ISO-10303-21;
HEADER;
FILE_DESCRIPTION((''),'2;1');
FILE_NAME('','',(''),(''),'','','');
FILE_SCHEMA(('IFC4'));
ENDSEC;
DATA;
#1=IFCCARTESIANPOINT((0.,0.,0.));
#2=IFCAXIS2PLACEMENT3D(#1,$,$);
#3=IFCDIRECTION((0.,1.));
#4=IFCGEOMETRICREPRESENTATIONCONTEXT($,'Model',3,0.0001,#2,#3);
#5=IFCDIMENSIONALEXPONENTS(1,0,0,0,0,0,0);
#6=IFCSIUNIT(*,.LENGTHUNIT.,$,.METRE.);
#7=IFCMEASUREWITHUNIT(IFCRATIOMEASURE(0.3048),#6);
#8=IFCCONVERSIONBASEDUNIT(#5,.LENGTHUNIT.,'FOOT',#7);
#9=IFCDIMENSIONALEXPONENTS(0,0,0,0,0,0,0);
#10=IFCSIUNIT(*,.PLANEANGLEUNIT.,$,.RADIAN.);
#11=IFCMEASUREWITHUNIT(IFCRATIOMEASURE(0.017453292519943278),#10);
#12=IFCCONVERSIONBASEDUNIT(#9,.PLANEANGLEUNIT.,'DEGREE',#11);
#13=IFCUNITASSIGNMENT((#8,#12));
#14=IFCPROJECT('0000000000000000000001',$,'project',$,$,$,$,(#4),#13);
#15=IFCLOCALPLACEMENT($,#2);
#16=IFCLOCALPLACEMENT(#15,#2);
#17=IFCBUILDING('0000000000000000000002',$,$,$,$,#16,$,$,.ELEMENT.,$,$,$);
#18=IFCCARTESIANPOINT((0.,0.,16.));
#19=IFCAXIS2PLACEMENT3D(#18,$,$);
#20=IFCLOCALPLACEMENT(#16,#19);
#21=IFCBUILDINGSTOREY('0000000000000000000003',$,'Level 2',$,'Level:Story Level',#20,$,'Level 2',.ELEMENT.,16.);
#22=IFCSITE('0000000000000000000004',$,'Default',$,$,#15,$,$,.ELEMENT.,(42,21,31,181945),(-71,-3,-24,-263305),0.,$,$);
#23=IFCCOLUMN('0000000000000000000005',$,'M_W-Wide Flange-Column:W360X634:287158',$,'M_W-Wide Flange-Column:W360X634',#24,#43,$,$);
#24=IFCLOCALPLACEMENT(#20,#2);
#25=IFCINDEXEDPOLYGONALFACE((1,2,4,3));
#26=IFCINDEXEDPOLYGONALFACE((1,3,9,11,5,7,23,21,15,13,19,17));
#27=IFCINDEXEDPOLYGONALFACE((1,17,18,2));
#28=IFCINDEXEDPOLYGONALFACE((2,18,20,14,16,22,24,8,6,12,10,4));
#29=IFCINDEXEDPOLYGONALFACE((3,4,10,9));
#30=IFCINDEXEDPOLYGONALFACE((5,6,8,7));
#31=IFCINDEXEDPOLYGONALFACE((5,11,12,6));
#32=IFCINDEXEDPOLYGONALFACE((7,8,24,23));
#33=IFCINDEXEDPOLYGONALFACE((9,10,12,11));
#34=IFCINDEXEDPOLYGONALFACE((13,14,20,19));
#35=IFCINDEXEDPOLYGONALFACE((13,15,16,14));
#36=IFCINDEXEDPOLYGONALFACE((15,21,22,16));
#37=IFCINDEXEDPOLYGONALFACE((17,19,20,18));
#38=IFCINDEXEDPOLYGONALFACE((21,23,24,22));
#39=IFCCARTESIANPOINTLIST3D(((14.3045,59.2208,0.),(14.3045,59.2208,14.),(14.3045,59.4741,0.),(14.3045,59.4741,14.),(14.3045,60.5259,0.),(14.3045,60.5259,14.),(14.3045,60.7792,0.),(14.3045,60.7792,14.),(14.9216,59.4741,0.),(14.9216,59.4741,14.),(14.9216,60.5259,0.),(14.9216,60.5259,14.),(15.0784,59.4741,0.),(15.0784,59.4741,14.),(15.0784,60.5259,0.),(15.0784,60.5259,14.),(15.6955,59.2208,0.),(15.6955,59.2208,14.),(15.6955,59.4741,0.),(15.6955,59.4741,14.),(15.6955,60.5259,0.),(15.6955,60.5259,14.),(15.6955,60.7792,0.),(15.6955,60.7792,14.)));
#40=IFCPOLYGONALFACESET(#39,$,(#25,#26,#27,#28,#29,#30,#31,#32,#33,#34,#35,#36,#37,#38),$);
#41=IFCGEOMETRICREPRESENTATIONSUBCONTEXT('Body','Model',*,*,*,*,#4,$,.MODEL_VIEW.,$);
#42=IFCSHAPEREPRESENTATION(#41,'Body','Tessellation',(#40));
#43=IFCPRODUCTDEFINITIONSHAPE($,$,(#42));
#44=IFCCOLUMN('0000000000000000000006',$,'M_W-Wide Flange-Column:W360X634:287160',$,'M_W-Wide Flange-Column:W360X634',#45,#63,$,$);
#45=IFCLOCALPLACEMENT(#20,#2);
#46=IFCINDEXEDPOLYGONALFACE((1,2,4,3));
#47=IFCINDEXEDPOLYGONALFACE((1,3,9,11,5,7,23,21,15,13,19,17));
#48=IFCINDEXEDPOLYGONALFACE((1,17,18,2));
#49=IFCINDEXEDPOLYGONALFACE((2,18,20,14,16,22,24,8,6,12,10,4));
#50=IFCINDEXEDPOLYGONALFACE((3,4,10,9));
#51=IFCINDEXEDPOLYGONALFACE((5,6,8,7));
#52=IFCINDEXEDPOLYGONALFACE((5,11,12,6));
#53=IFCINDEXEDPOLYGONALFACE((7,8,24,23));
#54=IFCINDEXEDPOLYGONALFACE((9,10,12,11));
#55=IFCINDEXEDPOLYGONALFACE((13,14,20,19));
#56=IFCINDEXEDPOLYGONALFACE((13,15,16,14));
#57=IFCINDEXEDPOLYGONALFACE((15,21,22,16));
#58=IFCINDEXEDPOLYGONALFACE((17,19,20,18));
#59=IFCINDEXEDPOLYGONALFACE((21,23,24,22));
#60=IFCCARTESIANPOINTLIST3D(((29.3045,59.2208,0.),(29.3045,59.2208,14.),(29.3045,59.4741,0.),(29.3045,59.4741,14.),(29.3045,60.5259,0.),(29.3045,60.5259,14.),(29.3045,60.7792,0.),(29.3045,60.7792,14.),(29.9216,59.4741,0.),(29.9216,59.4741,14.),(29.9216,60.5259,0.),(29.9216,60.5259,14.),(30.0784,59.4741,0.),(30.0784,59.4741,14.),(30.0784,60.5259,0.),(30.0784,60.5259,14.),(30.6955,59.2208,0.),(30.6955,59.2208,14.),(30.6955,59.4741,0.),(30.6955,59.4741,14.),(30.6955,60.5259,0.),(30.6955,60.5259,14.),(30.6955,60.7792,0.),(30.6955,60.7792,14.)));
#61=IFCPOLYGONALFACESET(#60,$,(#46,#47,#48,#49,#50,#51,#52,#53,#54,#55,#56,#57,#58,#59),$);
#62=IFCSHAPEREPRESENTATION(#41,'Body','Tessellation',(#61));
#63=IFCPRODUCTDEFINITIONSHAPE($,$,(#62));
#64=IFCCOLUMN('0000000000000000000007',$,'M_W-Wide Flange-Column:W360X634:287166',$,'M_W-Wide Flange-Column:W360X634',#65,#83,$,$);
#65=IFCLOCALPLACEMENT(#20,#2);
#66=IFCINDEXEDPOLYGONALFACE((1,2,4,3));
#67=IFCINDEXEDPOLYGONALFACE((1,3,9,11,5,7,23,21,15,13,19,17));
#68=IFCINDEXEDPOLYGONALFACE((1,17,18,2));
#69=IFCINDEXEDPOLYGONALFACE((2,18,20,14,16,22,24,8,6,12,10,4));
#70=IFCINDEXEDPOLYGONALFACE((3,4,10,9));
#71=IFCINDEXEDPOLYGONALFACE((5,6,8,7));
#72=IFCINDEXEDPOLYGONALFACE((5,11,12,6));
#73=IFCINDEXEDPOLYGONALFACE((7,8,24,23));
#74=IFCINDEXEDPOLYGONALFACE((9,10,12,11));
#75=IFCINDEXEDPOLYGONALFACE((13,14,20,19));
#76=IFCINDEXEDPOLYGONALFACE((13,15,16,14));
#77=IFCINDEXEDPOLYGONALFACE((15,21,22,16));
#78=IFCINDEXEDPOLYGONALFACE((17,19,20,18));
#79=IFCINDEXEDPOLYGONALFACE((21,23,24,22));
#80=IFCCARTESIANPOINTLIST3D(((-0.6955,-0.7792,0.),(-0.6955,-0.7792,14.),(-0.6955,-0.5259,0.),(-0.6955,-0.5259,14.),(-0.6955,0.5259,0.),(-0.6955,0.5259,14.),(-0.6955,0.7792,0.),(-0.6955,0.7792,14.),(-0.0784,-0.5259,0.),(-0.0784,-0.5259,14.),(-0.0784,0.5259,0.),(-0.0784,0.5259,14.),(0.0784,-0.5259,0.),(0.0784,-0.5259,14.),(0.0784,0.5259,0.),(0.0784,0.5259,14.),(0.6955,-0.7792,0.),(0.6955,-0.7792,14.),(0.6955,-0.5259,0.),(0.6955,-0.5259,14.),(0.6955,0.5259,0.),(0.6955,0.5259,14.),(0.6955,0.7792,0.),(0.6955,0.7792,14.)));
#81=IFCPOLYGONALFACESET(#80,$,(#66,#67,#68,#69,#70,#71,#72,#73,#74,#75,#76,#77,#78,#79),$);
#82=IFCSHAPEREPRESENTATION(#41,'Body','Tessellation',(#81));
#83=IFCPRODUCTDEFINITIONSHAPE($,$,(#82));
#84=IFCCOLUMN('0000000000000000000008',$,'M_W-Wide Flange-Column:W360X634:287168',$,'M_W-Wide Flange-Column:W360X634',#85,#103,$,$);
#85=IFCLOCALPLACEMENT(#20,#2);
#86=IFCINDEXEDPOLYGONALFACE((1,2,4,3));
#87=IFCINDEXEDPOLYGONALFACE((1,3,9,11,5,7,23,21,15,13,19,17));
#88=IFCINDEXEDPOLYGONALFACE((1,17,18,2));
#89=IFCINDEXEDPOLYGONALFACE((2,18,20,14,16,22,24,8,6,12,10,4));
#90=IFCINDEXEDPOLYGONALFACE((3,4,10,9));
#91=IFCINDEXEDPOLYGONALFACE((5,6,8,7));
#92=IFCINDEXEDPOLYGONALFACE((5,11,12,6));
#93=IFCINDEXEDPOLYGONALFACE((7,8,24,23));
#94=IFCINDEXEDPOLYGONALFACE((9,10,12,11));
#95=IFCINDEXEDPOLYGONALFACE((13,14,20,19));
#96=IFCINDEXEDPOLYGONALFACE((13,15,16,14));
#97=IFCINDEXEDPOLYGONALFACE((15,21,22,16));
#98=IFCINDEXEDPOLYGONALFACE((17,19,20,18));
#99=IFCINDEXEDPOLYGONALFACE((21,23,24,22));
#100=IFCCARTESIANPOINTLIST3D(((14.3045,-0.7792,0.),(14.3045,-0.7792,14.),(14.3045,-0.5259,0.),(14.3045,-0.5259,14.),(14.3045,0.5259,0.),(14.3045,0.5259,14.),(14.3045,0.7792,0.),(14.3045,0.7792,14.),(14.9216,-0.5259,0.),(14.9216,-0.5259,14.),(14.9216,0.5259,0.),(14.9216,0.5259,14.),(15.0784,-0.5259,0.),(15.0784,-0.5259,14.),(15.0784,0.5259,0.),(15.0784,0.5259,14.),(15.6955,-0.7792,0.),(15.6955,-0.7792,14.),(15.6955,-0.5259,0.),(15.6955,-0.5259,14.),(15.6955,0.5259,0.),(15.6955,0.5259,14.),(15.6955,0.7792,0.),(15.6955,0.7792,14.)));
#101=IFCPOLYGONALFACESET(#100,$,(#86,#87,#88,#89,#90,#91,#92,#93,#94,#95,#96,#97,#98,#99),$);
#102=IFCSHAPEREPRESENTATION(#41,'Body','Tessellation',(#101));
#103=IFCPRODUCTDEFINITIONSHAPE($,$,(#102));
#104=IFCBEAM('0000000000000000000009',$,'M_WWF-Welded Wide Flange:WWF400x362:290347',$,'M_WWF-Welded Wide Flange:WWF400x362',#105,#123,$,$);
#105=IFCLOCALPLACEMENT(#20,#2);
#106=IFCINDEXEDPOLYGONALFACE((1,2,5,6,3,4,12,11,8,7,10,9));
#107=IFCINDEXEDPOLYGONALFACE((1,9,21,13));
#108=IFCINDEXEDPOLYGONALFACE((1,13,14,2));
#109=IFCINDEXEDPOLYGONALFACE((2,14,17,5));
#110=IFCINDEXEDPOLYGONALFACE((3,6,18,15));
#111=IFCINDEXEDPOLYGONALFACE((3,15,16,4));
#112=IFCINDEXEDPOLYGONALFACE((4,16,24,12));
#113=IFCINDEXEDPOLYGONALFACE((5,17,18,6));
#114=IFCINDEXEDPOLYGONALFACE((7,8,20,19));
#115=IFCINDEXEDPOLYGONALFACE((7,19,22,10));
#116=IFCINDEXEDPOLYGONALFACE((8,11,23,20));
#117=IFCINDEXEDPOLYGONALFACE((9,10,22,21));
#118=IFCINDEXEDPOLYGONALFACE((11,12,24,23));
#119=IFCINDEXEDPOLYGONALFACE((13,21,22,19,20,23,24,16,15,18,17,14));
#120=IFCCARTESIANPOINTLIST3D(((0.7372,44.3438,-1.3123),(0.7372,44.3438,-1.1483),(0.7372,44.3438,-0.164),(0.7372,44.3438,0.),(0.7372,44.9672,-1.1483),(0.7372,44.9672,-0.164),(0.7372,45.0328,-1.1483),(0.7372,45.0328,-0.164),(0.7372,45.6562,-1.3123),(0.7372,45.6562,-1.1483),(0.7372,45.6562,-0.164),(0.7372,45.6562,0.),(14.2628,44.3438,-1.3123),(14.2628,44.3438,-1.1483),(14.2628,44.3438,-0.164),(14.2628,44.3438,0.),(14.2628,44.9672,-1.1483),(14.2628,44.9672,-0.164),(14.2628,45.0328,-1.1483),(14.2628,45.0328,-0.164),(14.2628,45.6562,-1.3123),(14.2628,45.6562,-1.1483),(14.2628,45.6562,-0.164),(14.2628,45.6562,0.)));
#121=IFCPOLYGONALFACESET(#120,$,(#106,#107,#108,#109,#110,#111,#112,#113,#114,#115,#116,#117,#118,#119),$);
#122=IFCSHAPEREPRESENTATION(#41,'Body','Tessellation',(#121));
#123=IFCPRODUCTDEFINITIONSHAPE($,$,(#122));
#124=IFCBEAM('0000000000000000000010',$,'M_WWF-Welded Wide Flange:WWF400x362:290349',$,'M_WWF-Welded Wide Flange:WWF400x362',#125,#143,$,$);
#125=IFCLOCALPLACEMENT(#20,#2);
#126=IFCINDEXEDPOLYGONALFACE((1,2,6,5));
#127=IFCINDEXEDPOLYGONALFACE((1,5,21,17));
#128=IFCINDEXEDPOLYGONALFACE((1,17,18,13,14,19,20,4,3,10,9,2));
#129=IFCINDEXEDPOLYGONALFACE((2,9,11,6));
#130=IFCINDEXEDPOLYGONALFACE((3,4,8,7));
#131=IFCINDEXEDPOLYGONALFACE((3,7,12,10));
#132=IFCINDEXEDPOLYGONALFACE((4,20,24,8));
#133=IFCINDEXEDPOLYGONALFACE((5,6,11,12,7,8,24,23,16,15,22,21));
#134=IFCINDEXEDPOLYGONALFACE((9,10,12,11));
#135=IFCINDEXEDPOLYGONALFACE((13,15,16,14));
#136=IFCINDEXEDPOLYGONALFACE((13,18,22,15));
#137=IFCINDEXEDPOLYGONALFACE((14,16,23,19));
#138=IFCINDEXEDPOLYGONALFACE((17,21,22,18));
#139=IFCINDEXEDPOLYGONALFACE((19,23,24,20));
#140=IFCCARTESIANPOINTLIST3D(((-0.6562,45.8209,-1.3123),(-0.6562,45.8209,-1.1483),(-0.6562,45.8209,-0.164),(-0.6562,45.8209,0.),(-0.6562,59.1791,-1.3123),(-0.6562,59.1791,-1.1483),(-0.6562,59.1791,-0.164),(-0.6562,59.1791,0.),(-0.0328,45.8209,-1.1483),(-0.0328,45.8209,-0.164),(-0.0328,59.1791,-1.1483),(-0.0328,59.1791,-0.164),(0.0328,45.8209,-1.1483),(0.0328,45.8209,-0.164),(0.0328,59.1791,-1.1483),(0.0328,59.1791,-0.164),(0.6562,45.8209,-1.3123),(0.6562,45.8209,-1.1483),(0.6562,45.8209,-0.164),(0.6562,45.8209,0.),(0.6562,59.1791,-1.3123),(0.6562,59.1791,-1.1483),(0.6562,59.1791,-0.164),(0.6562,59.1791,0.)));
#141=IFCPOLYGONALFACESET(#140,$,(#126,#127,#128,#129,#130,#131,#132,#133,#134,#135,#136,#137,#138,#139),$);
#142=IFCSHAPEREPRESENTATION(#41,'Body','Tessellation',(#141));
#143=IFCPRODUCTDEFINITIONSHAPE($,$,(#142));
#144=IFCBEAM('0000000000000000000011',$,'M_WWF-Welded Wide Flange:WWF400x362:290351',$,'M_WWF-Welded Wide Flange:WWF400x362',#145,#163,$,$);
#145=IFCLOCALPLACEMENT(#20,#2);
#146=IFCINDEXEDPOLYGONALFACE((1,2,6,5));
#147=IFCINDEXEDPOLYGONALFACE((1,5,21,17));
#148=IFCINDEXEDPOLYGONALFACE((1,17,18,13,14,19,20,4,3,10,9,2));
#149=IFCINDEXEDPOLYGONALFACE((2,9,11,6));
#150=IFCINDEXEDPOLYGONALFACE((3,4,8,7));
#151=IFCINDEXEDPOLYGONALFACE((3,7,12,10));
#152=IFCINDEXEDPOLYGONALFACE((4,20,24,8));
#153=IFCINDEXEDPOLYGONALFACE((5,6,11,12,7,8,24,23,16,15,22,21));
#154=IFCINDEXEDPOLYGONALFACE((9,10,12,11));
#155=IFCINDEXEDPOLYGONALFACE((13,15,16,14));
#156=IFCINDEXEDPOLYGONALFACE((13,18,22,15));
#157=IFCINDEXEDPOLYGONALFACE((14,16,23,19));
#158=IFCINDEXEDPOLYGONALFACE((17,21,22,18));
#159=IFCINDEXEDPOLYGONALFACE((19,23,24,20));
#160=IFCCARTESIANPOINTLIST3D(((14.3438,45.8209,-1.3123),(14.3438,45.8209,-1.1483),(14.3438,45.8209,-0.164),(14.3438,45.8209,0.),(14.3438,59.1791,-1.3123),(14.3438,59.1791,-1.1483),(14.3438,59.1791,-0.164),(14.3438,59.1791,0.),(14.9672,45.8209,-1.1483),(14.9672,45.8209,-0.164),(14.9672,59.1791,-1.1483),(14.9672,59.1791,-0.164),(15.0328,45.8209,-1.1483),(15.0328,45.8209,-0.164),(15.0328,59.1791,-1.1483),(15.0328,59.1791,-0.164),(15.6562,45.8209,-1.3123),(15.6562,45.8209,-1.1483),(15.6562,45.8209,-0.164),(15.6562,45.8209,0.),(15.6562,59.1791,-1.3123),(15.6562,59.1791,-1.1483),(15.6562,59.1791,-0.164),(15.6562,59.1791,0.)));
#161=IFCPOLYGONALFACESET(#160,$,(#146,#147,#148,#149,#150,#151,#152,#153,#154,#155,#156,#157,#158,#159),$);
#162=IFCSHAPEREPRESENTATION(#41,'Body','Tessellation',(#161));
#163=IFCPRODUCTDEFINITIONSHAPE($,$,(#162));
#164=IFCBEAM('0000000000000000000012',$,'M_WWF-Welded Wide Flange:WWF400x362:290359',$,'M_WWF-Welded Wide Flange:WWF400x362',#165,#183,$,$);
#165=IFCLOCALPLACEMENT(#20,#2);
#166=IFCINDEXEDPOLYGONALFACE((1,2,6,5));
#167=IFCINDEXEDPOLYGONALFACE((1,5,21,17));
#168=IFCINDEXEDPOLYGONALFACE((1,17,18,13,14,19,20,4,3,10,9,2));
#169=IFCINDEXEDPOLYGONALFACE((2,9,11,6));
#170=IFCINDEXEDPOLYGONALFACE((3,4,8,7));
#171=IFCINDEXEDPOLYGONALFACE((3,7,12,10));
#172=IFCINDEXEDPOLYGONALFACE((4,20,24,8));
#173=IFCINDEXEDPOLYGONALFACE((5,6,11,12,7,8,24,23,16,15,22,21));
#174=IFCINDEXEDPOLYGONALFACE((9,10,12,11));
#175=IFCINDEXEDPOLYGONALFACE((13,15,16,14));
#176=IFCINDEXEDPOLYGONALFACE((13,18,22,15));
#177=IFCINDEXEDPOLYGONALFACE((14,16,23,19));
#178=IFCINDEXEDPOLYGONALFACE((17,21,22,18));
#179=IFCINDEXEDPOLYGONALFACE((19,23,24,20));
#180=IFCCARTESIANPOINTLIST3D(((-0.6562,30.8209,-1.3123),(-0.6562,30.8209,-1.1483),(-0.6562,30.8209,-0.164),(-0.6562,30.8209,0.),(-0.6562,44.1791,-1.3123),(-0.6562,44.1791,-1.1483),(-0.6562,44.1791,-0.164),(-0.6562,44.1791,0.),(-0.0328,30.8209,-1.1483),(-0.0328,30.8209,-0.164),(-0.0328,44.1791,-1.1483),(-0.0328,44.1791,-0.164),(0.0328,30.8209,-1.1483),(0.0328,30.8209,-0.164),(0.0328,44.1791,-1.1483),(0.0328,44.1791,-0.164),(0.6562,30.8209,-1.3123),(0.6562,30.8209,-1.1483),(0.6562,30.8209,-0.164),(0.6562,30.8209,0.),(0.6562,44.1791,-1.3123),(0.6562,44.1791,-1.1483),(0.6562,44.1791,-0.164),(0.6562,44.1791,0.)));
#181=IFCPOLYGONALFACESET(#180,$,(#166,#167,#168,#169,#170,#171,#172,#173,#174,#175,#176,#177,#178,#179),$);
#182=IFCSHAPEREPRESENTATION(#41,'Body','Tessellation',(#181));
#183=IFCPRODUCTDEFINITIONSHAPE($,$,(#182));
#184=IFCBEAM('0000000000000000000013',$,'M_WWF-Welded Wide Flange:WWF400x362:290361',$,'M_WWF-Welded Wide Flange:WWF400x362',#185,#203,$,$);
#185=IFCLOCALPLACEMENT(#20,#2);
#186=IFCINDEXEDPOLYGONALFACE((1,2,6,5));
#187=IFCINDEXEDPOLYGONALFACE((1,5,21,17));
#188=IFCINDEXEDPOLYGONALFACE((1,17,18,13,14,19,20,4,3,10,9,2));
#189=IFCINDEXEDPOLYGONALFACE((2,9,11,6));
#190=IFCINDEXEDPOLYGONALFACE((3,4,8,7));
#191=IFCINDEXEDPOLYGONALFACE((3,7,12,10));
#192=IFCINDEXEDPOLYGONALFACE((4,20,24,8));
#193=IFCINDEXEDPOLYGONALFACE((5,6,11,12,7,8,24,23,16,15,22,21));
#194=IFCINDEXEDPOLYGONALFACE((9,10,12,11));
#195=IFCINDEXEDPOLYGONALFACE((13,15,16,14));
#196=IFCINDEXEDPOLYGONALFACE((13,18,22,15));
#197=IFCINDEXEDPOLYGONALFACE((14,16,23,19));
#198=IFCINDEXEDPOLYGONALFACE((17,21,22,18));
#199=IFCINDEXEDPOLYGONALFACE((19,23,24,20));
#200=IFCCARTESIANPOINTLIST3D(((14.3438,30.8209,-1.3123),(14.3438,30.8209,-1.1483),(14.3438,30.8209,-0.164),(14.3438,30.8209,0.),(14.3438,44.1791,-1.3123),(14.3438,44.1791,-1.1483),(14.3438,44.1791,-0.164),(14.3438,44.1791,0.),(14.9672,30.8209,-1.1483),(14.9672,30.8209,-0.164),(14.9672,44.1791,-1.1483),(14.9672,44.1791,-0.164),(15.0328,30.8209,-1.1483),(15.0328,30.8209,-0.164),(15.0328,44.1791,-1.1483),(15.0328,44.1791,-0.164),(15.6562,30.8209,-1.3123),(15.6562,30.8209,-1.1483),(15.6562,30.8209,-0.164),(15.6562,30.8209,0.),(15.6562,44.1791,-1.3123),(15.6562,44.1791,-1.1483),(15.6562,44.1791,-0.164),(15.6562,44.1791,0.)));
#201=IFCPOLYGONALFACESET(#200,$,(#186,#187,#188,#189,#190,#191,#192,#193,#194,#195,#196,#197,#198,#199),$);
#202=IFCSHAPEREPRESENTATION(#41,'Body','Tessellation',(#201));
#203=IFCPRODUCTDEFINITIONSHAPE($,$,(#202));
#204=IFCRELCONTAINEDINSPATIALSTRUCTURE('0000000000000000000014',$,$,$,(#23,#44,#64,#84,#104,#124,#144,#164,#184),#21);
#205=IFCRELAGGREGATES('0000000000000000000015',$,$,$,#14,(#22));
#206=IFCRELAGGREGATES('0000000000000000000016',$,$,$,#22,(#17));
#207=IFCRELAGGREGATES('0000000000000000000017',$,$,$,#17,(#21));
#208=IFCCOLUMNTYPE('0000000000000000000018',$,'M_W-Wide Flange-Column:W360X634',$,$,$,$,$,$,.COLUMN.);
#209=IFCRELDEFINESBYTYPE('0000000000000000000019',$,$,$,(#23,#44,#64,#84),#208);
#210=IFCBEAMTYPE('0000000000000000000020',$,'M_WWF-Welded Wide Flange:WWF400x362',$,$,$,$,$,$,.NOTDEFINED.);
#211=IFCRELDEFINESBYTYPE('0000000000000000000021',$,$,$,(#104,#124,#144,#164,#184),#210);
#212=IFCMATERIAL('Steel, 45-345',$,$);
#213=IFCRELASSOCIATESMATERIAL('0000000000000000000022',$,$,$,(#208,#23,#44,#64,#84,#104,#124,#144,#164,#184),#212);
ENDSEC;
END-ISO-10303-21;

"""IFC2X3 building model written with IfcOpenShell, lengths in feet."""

from ifc_helpers import new_model, entity, si_unit, converted_unit, direction, frame, frame_2d, origin, place, context, subcontext, project, spatial, polyline, i_section, outline, extrude, source, transform, mapped, material, type_object, type_shapes, element, save


model = new_model("IFC2X3")

# Units and contexts
model_context = context("Model", 3, precision=0.0001, world=origin(), true_north=direction((0.0, 1.0)))
body_context = subcontext(model_context, "Body", "Model", "MODEL_VIEW")
ifc_project = project(units=[converted_unit("LENGTHUNIT", "FOOT", entity("IfcRatioMeasure", 0.3048), si_unit("LENGTHUNIT", "METRE"), dimensions=[1, 0, 0, 0, 0, 0, 0]), converted_unit("PLANEANGLEUNIT", "DEGREE", entity("IfcRatioMeasure", 0.017453292519943278), si_unit("PLANEANGLEUNIT", "RADIAN"), dimensions=[0, 0, 0, 0, 0, 0, 0])], contexts=[model_context])

# Site, building, storey
site_placement = place(None, origin())
site = spatial("IfcSite", under=ifc_project, at=site_placement, Name="Default", CompositionType="ELEMENT", RefLatitude=(42, 21, 31, 181945), RefLongitude=(-71, -3, -24, -263305), RefElevation=0.0)
building_placement = place(site_placement, origin())
building = spatial("IfcBuilding", under=site, at=building_placement, CompositionType="ELEMENT")
storey_placement = place(building_placement, frame((0.0, 0.0, 16.0)))
storey = spatial("IfcBuildingStorey", under=building, at=storey_placement, Name="Level 2", ObjectType="Level:Story Level", LongName="Level 2", CompositionType="ELEMENT", Elevation=16.0)

# Columns
ifc_material = material(Name="Steel, 45-345")
column_type = type_object("IfcColumnType", Name="M_W-Wide Flange-Column:W360X634", PredefinedType="COLUMN", material=ifc_material)
shared_shape = source(origin(), body_context, "Body", "SweptSolid", [
    extrude(outline(polyline([(0.5259, -0.6955), (0.7792, -0.6955), (0.7792, 0.6955), (0.5259, 0.6955), (0.5259, 0.0784), (-0.5259, 0.0784), (-0.5259, 0.6955), (-0.7792, 0.6955), (-0.7792, -0.6955), (-0.5259, -0.6955), (-0.5259, -0.0784), (0.5259, -0.0784), (0.5259, -0.6955)])), frame((0.0, 0.0, 16.0), z_axis=(0.0, 0.0, 1.0), x_axis=(0.0, -1.0, 0.0)), (0.0, 0.0, 1.0), 14.0),
])
type_shapes(column_type, [shared_shape])
for number, where, name in (
    (1, (15.0, 60.0, -16.0), "M_W-Wide Flange-Column:W360X634:287158"),
    (2, (30.0, 60.0, -16.0), "M_W-Wide Flange-Column:W360X634:287160"),
    (3, (0.0, 0.0, -16.0), "M_W-Wide Flange-Column:W360X634:287166"),
    (4, (15.0, 0.0, -16.0), "M_W-Wide Flange-Column:W360X634:287168"),
):
    element("IfcColumn", number, at=place(storey_placement, frame(where)), inside=storey, type_object=column_type, material=ifc_material, Name=name, ObjectType="M_W-Wide Flange-Column:W360X634", context=body_context, shape_type="MappedRepresentation", body=[
        mapped(shared_shape, transform((0.0, 0.0, 0.0), scale=1.0)),
    ])

# Beams
beam_type = type_object("IfcBeamType", Name="M_WWF-Welded Wide Flange:WWF400x362", PredefinedType="NOTDEFINED")
beam_1_placement = place(storey_placement, frame((0.0, 45.0, 0.0)))
element("IfcBeam", 5, at=beam_1_placement, inside=storey, type_object=beam_type, material=ifc_material, Name="M_WWF-Welded Wide Flange:WWF400x362:290347", ObjectType="M_WWF-Welded Wide Flange:WWF400x362", context=body_context, shape_type="SweptSolid", body=[
    extrude(i_section(OverallWidth=1.3123, OverallDepth=1.3123, WebThickness=0.0656, FlangeThickness=0.164, at=frame_2d((0.0, 0.0), x_axis=(0.0, 1.0))), frame((0.7372, 0.0, -0.6562), z_axis=(1.0, 0.0, 0.0), x_axis=(0.0, 0.0, -1.0)), (0.0, 0.0, 1.0), 13.5256),
])
beam_2_placement = place(storey_placement, frame((0.0, 45.0, 0.0), z_axis=(0.0, 0.0, 1.0), x_axis=(0.0, 1.0, 0.0)))
element("IfcBeam", 6, at=beam_2_placement, inside=storey, type_object=beam_type, material=ifc_material, Name="M_WWF-Welded Wide Flange:WWF400x362:290349", ObjectType="M_WWF-Welded Wide Flange:WWF400x362", context=body_context, shape_type="SweptSolid", body=[
    extrude(i_section(OverallWidth=1.3123, OverallDepth=1.3123, WebThickness=0.0656, FlangeThickness=0.164, at=frame_2d((0.0, 0.0), x_axis=(0.0, 1.0))), frame((0.8209, 0.0, -0.6562), z_axis=(1.0, 0.0, 0.0), x_axis=(0.0, 0.0, -1.0)), (0.0, 0.0, 1.0), 13.3583),
])
beam_3_placement = place(storey_placement, frame((15.0, 45.0, 0.0), z_axis=(0.0, 0.0, 1.0), x_axis=(0.0, 1.0, 0.0)))
element("IfcBeam", 7, at=beam_3_placement, inside=storey, type_object=beam_type, material=ifc_material, Name="M_WWF-Welded Wide Flange:WWF400x362:290351", ObjectType="M_WWF-Welded Wide Flange:WWF400x362", context=body_context, shape_type="SweptSolid", body=[
    extrude(i_section(OverallWidth=1.3123, OverallDepth=1.3123, WebThickness=0.0656, FlangeThickness=0.164, at=frame_2d((0.0, 0.0), x_axis=(0.0, 1.0))), frame((0.8209, 0.0, -0.6562), z_axis=(1.0, 0.0, 0.0), x_axis=(0.0, 0.0, -1.0)), (0.0, 0.0, 1.0), 13.3583),
])
beam_4_placement = place(storey_placement, frame((0.0, 30.0, 0.0), z_axis=(0.0, 0.0, 1.0), x_axis=(0.0, 1.0, 0.0)))
element("IfcBeam", 8, at=beam_4_placement, inside=storey, type_object=beam_type, material=ifc_material, Name="M_WWF-Welded Wide Flange:WWF400x362:290359", ObjectType="M_WWF-Welded Wide Flange:WWF400x362", context=body_context, shape_type="SweptSolid", body=[
    extrude(i_section(OverallWidth=1.3123, OverallDepth=1.3123, WebThickness=0.0656, FlangeThickness=0.164, at=frame_2d((0.0, 0.0), x_axis=(0.0, 1.0))), frame((0.8209, 0.0, -0.6562), z_axis=(1.0, 0.0, 0.0), x_axis=(0.0, 0.0, -1.0)), (0.0, 0.0, 1.0), 13.3583),
])
beam_5_placement = place(storey_placement, frame((15.0, 30.0, 0.0), z_axis=(0.0, 0.0, 1.0), x_axis=(0.0, 1.0, 0.0)))
element("IfcBeam", 9, at=beam_5_placement, inside=storey, type_object=beam_type, material=ifc_material, Name="M_WWF-Welded Wide Flange:WWF400x362:290361", ObjectType="M_WWF-Welded Wide Flange:WWF400x362", context=body_context, shape_type="SweptSolid", body=[
    extrude(i_section(OverallWidth=1.3123, OverallDepth=1.3123, WebThickness=0.0656, FlangeThickness=0.164, at=frame_2d((0.0, 0.0), x_axis=(0.0, 1.0))), frame((0.8209, 0.0, -0.6562), z_axis=(1.0, 0.0, 0.0), x_axis=(0.0, 0.0, -1.0)), (0.0, 0.0, 1.0), 13.3583),
])

save(model, "model.ifc")
